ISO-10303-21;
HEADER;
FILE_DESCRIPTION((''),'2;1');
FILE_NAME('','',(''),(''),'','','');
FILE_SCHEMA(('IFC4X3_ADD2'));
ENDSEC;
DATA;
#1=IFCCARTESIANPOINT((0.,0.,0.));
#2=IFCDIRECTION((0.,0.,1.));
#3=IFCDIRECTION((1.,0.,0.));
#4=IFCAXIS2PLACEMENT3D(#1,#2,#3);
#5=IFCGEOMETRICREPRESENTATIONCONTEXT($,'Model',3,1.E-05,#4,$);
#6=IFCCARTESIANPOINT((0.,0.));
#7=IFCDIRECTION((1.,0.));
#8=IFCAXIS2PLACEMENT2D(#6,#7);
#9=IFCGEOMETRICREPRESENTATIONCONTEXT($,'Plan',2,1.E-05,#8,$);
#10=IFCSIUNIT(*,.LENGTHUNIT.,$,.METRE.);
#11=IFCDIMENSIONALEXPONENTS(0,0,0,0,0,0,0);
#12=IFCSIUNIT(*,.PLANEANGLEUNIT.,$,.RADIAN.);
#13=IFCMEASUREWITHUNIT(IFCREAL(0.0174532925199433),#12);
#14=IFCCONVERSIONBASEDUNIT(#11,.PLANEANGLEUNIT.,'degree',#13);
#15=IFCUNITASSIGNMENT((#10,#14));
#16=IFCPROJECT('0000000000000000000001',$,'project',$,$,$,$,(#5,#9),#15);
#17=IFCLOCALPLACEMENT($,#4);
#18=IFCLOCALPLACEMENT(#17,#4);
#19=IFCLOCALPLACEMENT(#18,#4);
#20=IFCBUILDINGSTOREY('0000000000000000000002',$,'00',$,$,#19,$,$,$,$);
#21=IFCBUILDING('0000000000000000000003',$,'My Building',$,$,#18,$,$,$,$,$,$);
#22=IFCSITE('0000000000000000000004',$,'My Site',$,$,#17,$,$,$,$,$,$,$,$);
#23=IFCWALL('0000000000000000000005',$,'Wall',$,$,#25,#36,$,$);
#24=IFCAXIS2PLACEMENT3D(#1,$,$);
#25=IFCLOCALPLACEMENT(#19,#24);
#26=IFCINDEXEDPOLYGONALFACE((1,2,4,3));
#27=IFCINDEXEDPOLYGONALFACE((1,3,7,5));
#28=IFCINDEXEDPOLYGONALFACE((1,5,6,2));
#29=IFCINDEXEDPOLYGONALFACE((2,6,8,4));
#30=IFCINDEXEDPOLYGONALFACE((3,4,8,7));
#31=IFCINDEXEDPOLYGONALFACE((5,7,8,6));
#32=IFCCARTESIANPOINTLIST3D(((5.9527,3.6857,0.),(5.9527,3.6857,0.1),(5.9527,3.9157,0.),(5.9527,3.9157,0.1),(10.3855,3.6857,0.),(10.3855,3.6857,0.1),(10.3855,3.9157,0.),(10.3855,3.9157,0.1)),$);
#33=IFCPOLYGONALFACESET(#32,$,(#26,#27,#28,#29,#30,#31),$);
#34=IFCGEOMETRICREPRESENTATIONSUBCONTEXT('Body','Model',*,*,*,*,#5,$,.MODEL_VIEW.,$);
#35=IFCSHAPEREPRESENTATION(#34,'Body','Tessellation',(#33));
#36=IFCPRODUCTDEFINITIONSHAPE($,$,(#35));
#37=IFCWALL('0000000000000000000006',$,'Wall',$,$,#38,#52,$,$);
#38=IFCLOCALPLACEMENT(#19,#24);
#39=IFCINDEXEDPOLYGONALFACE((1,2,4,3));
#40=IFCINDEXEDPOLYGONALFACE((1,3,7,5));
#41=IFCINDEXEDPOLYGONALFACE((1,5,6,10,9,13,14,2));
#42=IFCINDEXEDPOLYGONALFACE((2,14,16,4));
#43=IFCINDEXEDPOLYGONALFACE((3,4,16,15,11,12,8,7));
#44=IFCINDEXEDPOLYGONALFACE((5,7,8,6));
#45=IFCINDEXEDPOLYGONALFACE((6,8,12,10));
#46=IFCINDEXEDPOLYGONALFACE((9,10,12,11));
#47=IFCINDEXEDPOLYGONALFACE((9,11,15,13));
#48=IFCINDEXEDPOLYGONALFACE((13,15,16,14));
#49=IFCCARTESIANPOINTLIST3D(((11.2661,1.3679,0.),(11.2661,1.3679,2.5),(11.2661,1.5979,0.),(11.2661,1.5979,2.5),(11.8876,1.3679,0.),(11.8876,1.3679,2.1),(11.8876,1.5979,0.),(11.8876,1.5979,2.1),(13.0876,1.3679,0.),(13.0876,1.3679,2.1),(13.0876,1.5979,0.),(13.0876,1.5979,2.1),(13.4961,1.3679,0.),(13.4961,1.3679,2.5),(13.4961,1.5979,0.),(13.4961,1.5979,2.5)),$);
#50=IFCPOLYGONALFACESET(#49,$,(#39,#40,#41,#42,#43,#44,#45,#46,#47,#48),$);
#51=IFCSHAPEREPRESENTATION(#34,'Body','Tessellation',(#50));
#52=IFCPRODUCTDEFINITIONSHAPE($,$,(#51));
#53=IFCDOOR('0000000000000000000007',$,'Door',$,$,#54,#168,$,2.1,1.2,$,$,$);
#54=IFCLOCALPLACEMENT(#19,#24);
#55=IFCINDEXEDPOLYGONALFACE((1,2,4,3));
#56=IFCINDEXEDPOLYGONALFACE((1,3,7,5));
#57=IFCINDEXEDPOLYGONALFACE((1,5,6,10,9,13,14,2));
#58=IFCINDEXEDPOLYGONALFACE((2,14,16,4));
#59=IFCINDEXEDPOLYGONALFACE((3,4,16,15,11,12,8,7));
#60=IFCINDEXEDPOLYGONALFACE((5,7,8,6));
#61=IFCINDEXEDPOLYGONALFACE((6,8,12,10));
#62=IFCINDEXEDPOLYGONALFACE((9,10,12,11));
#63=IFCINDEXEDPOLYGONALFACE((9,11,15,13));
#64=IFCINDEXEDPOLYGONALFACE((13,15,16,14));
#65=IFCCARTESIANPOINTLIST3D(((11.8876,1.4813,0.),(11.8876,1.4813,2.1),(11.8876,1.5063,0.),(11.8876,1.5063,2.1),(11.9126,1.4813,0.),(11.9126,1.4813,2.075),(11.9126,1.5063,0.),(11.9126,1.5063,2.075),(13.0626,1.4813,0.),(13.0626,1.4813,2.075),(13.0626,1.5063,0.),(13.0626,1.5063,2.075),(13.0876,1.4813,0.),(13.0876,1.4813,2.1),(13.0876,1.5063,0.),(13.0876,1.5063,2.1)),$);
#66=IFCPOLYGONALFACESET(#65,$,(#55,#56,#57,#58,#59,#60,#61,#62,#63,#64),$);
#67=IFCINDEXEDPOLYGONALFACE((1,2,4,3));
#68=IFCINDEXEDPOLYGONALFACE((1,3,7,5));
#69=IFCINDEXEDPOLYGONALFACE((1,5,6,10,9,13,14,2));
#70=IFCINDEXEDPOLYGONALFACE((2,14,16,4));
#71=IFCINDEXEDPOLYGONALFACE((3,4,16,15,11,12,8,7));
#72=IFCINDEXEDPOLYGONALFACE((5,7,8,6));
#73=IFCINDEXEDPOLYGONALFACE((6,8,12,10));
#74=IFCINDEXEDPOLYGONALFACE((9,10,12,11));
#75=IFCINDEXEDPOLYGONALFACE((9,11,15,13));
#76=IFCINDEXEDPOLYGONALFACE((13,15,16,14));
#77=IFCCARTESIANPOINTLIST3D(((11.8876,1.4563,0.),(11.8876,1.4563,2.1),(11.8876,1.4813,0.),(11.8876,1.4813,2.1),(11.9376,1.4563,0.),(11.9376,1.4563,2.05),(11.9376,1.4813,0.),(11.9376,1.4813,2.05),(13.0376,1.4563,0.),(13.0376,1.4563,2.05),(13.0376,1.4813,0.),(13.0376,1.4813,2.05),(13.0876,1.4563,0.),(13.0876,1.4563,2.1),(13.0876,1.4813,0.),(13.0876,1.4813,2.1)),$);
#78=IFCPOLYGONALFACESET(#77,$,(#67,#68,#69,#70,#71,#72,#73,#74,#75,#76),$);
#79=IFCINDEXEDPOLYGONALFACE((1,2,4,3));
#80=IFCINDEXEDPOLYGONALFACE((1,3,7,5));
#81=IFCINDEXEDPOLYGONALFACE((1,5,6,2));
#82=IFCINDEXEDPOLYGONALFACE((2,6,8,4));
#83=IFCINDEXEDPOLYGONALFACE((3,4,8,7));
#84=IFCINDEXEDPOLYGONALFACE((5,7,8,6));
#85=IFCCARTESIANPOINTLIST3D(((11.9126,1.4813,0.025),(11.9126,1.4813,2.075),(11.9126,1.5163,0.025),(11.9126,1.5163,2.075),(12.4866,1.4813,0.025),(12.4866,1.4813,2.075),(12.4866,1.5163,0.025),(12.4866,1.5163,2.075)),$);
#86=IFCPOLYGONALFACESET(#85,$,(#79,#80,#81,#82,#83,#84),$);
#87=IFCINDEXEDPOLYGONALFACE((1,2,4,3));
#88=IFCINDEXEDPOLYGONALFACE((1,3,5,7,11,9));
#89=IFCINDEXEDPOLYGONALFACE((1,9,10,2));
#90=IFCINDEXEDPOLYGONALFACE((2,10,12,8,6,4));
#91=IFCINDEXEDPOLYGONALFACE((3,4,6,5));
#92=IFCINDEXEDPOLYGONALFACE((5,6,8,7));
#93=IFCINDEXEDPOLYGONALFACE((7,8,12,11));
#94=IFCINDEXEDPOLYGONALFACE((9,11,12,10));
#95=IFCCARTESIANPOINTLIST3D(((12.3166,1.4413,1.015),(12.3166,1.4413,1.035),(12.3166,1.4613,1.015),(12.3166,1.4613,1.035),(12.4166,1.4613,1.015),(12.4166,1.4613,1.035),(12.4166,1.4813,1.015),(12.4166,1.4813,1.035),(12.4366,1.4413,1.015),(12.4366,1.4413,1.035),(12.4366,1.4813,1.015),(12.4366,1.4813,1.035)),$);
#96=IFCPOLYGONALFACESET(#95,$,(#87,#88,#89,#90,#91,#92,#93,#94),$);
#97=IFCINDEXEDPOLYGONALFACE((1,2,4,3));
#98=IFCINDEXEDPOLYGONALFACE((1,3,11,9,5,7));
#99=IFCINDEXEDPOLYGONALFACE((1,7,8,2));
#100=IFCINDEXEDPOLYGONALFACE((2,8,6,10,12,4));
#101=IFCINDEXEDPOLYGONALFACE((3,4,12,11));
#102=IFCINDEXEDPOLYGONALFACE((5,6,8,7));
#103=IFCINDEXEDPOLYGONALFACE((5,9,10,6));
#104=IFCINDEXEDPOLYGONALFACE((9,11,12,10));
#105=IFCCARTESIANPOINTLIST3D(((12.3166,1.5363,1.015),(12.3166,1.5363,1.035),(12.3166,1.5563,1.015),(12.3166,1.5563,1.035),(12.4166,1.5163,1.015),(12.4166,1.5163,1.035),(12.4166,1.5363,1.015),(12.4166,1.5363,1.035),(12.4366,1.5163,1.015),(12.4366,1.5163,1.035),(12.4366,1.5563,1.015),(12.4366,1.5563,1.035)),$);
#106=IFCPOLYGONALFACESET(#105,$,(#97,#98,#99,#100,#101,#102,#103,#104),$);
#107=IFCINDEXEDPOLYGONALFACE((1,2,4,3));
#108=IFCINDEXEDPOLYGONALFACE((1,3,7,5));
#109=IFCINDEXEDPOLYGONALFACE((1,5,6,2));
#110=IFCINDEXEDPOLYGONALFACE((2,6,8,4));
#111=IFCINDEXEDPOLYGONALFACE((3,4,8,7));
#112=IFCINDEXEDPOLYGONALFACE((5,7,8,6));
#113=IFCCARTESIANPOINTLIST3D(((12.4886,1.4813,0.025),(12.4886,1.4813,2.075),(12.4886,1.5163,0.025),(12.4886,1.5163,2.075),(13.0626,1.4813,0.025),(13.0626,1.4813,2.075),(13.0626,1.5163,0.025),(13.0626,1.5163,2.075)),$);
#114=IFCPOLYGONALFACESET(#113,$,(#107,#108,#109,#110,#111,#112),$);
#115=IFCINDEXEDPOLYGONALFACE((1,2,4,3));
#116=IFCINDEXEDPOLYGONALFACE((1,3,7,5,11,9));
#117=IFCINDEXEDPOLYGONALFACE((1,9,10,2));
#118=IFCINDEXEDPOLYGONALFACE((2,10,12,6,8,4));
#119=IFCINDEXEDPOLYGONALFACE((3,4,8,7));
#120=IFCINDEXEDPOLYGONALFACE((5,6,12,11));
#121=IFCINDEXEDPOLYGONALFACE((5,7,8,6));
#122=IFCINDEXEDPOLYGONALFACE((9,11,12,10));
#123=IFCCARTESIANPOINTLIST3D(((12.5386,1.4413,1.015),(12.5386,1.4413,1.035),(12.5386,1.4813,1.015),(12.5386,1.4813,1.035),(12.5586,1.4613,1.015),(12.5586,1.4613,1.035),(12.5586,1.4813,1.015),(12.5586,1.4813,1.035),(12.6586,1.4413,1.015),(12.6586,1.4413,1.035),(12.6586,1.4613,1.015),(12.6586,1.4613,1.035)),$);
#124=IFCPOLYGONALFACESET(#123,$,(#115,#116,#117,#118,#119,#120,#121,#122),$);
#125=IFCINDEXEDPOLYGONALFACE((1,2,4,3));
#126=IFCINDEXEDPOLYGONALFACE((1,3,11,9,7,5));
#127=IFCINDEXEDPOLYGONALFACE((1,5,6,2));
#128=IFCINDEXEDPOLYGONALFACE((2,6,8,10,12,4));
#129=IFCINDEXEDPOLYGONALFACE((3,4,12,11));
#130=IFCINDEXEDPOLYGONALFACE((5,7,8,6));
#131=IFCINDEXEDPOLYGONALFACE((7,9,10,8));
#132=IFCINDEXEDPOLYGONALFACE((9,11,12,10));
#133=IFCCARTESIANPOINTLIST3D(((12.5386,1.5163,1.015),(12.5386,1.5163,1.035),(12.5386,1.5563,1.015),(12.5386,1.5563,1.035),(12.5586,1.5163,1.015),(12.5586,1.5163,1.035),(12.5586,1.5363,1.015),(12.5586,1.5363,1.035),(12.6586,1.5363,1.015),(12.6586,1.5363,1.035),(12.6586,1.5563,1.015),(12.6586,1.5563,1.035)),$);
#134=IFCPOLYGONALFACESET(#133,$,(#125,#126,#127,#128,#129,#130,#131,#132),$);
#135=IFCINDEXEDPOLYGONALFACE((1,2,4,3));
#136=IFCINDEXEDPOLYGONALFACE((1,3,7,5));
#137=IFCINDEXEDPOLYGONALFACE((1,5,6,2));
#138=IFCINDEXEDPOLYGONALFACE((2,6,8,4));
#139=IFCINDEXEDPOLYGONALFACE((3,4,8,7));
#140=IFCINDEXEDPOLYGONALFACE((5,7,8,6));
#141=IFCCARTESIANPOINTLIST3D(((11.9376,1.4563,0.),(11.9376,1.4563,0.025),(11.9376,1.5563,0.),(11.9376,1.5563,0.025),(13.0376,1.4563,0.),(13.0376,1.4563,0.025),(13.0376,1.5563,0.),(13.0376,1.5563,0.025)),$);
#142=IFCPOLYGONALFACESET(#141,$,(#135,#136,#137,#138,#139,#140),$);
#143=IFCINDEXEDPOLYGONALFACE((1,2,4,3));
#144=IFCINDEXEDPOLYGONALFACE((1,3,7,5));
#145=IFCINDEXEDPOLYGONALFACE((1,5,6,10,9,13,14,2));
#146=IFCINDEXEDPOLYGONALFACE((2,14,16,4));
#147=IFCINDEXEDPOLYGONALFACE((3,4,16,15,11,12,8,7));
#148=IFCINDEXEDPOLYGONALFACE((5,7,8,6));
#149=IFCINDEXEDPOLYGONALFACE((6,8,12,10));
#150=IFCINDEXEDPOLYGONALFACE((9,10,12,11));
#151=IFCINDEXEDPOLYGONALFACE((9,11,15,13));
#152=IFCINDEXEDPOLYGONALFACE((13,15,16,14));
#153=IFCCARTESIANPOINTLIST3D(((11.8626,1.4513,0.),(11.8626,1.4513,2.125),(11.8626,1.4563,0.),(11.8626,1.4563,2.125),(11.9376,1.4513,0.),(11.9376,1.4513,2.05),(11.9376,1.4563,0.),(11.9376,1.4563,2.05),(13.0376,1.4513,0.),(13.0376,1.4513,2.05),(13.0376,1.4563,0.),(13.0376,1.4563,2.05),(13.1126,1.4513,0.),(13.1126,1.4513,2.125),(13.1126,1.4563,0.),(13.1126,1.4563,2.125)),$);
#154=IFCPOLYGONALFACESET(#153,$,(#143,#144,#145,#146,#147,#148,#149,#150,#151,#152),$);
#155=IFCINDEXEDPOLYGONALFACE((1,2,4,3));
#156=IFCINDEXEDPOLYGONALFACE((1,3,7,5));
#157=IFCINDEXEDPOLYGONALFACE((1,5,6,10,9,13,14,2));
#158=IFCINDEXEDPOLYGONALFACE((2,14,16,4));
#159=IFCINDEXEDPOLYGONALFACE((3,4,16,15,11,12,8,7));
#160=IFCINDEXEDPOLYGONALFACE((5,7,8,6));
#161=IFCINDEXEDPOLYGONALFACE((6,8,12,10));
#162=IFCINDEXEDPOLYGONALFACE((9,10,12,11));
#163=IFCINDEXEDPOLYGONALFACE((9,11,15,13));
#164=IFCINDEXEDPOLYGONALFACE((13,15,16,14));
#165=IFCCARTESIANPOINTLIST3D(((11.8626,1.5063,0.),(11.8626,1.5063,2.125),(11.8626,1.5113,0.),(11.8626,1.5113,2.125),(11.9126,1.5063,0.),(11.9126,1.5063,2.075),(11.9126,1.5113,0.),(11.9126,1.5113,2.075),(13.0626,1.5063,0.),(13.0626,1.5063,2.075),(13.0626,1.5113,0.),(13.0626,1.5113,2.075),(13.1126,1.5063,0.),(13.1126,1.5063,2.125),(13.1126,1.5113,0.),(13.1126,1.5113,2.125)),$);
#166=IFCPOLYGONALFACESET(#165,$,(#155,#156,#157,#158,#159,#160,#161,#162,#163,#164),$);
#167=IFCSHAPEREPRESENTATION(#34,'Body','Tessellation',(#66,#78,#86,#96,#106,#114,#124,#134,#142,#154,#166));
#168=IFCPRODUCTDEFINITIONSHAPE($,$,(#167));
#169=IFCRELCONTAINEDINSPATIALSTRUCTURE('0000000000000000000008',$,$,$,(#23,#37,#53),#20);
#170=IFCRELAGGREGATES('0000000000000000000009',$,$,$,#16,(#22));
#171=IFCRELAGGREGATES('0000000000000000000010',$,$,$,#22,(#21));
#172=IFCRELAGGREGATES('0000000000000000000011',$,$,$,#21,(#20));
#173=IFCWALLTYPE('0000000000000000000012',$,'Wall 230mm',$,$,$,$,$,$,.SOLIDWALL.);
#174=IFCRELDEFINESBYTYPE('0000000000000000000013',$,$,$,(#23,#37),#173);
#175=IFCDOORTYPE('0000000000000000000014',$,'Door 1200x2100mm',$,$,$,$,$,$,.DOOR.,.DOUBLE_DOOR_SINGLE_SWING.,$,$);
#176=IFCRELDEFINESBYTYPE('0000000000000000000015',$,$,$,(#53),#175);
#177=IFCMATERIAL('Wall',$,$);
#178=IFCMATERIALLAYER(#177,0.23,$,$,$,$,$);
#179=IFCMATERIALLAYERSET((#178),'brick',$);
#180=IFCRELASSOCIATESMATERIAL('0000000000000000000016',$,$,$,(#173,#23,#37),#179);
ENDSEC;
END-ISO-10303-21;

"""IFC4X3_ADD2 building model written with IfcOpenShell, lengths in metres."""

from ifc_helpers import new_model, entity, si_unit, converted_unit, frame, origin_with_axes, origin_2d_with_axis, place, context, subcontext, project, spatial, line, indexed_curve, outline, extrude, shape, source, transform, mapped, material, layer, layer_set, layer_usage, type_object, type_shapes, element, fill, save


model = new_model("IFC4X3_ADD2")

# Units and contexts
model_context = context("Model", 3, precision=1e-05, world=origin_with_axes())
plan_context = context("Plan", 2, precision=1e-05, world=origin_2d_with_axis())
body_context_1 = subcontext(model_context, "Body", "Model", "MODEL_VIEW")
body_context_2 = subcontext(plan_context, "Body", "Plan", "PLAN_VIEW")
ifc_project = project(units=[si_unit("LENGTHUNIT", "METRE"), converted_unit("PLANEANGLEUNIT", "degree", entity("IfcReal", 0.0174532925199433), si_unit("PLANEANGLEUNIT", "RADIAN"), dimensions=[0, 0, 0, 0, 0, 0, 0])], contexts=[model_context, plan_context])

# Site, building, storey
site_placement = place(None, origin_with_axes())
site = spatial("IfcSite", under=ifc_project, at=site_placement, Name="My Site")
building_placement = place(site_placement, origin_with_axes())
building = spatial("IfcBuilding", under=site, at=building_placement, Name="My Building")
storey_placement = place(building_placement, origin_with_axes())
storey = spatial("IfcBuildingStorey", under=building, at=storey_placement, Name="00")

# Wall
ifc_material_1 = material(Name="Wall")
ifc_layer_1 = layer(ifc_material_1, 0.23)
ifc_layer_set_1 = layer_set([ifc_layer_1], Name="brick")
ifc_layer_usage_1 = layer_usage(ifc_layer_set_1, "AXIS2", "POSITIVE", 0.0)
wall_type_1 = type_object("IfcWallType", Name="Wall 230mm", PredefinedType="SOLIDWALL", material=ifc_layer_set_1)
wall_1_placement = place(storey_placement, frame((5.9527, 3.6857, 0.0), z_axis=(0.0, 0.0, 1.0), x_axis=(1.0, 0.0, 0.0)))
element("IfcWall", 1, at=wall_1_placement, inside=storey, type_object=wall_type_1, material=ifc_layer_usage_1, Name="Wall", context=body_context_1, shape_type="SweptSolid", body=[
    extrude(outline(indexed_curve([(0.0, 0.0), (0.0, 0.23), (4.4327, 0.23), (4.4327, 0.0), (0.0, 0.0)], self_intersect=False)), origin_with_axes(), (0.0, 0.0, 1.0), 0.1),
])

# Wall, opening, door
ifc_layer_usage_2 = layer_usage(ifc_layer_set_1, "AXIS2", "POSITIVE", 0.0)
wall_2_placement = place(storey_placement, frame((11.2661, 1.3679, 0.0), z_axis=(0.0, 0.0, 1.0), x_axis=(1.0, 0.0, 0.0)))
wall_2 = element("IfcWall", 2, at=wall_2_placement, inside=storey, type_object=wall_type_1, material=ifc_layer_usage_2, Name="Wall", context=body_context_1, shape_type="SweptSolid", body=[
    extrude(outline(indexed_curve([(0.0, 0.0), (0.0, 0.23), (2.23, 0.23), (2.23, 0.0), (0.0, 0.0)], self_intersect=False)), origin_with_axes(), (0.0, 0.0, 1.0), 2.5),
])
shared_shape_1 = source(origin_with_axes(), body_context_1, "Body", "SweptSolid", [
    extrude(outline(indexed_curve([(0.0, 0.0), (1.2, 0.0), (1.2, 2.1), (0.0, 2.1)], segments=[line(1, 2, 3, 4, 1)])), frame((0.0, -0.6, 0.0), z_axis=(0.0, -1.0, 0.0), x_axis=(1.0, 0.0, 0.0)), (0.0, 0.0, -1.0), 1.2),
])
opening_1_placement = place(wall_2_placement, frame((0.6215, 0.0885, 0.0), z_axis=(0.0, 0.0, 1.0), x_axis=(1.0, 0.0, 0.0)))
opening_1 = element("IfcOpeningElement", 3, at=opening_1_placement, cuts=wall_2, PredefinedType="OPENING", context=body_context_1, shape_type="MappedRepresentation", body=[
    mapped(shared_shape_1, transform((0.0, 0.0, 0.0), x_axis=(1.0, 0.0, 0.0), y_axis=(0.0, 1.0, 0.0), z_axis=(0.0, 0.0, 1.0), scale=1.0)),
])
door_type_1 = type_object("IfcDoorType", Name="Door 1200x2100mm", OperationType="DOUBLE_DOOR_SINGLE_SWING", PredefinedType="DOOR")
shared_shape_2 = source(origin_with_axes(), body_context_1, "Body", "SweptSolid", [
    extrude(outline(indexed_curve([(0.0, 0.0), (0.0, 2.1), (1.2, 2.1), (1.2, 0.0), (1.175, 0.0), (1.175, 2.075), (0.025, 2.075), (0.025, 0.0)], segments=[line(1, 2, 3, 4, 5, 6, 7, 8, 1)])), frame((0.0, 0.025, 0.0), z_axis=(0.0, -1.0, 0.0), x_axis=(1.0, 0.0, 0.0)), (0.0, 0.0, -1.0), 0.025),
    extrude(outline(indexed_curve([(0.0, 0.0), (0.0, 2.1), (1.2, 2.1), (1.2, 0.0), (1.15, 0.0), (1.15, 2.05), (0.05, 2.05), (0.05, 0.0)], segments=[line(1, 2, 3, 4, 5, 6, 7, 8, 1)])), frame((0.0, 0.0, 0.0), z_axis=(0.0, -1.0, 0.0), x_axis=(1.0, 0.0, 0.0)), (0.0, 0.0, -1.0), 0.025),
    extrude(outline(indexed_curve([(0.0, 0.0), (0.574, 0.0), (0.574, 0.035), (0.0, 0.035)], segments=[line(1, 2, 3, 4, 1)])), frame((0.025, 0.025, 0.025), z_axis=(0.0, 0.0, 1.0), x_axis=(1.0, 0.0, 0.0)), (0.0, 0.0, 1.0), 2.05),
    extrude(outline(indexed_curve([(0.0, 0.0), (0.0, -0.04), (-0.12, -0.04), (-0.12, -0.02), (-0.02, -0.02), (-0.02, 0.0)], segments=[line(1, 2, 3, 4, 5, 6, 1)])), frame((0.549, 0.025, 1.015), z_axis=(0.0, 0.0, 1.0), x_axis=(1.0, 0.0, 0.0)), (0.0, 0.0, 1.0), 0.02),
    extrude(outline(indexed_curve([(0.0, 0.0), (0.0, 0.04), (-0.12, 0.04), (-0.12, 0.02), (-0.02, 0.02), (-0.02, 0.0)], segments=[line(1, 2, 3, 4, 5, 6, 1)])), frame((0.549, 0.06, 1.015), z_axis=(0.0, 0.0, 1.0), x_axis=(1.0, 0.0, 0.0)), (0.0, 0.0, 1.0), 0.02),
    extrude(outline(indexed_curve([(0.0, 0.0), (-0.574, 0.0), (-0.574, 0.035), (0.0, 0.035)], segments=[line(1, 2, 3, 4, 1)])), frame((1.175, 0.025, 0.025), z_axis=(0.0, 0.0, 1.0), x_axis=(1.0, 0.0, 0.0)), (0.0, 0.0, 1.0), 2.05),
    extrude(outline(indexed_curve([(0.0, 0.0), (0.0, -0.04), (0.12, -0.04), (0.12, -0.02), (0.02, -0.02), (0.02, 0.0)], segments=[line(1, 2, 3, 4, 5, 6, 1)])), frame((0.651, 0.025, 1.015), z_axis=(0.0, 0.0, 1.0), x_axis=(1.0, 0.0, 0.0)), (0.0, 0.0, 1.0), 0.02),
    extrude(outline(indexed_curve([(0.0, 0.0), (0.0, 0.04), (0.12, 0.04), (0.12, 0.02), (0.02, 0.02), (0.02, 0.0)], segments=[line(1, 2, 3, 4, 5, 6, 1)])), frame((0.651, 0.06, 1.015), z_axis=(0.0, 0.0, 1.0), x_axis=(1.0, 0.0, 0.0)), (0.0, 0.0, 1.0), 0.02),
    extrude(outline(indexed_curve([(0.0, 0.0), (1.1, 0.0), (1.1, 0.1), (0.0, 0.1)], segments=[line(1, 2, 3, 4, 1)])), frame((0.05, 0.0, 0.0), z_axis=(0.0, 0.0, 1.0), x_axis=(1.0, 0.0, 0.0)), (0.0, 0.0, 1.0), 0.025),
    extrude(outline(indexed_curve([(0.0, 0.0), (0.0, 2.125), (1.25, 2.125), (1.25, 0.0), (1.175, 0.0), (1.175, 2.05), (0.075, 2.05), (0.075, 0.0)], segments=[line(1, 2, 3, 4, 5, 6, 7, 8, 1)])), frame((-0.025, -0.005, 0.0), z_axis=(0.0, -1.0, 0.0), x_axis=(1.0, 0.0, 0.0)), (0.0, 0.0, -1.0), 0.005),
    extrude(outline(indexed_curve([(0.0, 0.0), (0.0, 2.125), (1.25, 2.125), (1.25, 0.0), (1.2, 0.0), (1.2, 2.075), (0.05, 2.075), (0.05, 0.0)], segments=[line(1, 2, 3, 4, 5, 6, 7, 8, 1)])), frame((-0.025, 0.05, 0.0), z_axis=(0.0, -1.0, 0.0), x_axis=(1.0, 0.0, 0.0)), (0.0, 0.0, -1.0), 0.005),
])
shared_shape_3 = source(origin_with_axes(), body_context_2, "Body", "Curve2D", [
    entity("IfcIndexedPolyCurve", entity("IfcCartesianPointList2D", [[0.0, 0.0], [0.0, 0.05], [0.025, 0.05], [0.025, 0.025], [0.05, 0.025], [0.05, 0.0]]), [entity("IfcLineIndex", [1, 2, 3, 4, 5, 6, 1])]),
    entity("IfcIndexedPolyCurve", entity("IfcCartesianPointList2D", [[1.2, 0.0], [1.2, 0.05], [1.175, 0.05], [1.175, 0.025], [1.15, 0.025], [1.15, 0.0]]), [entity("IfcLineIndex", [1, 2, 3, 4, 5, 6, 1])]),
    entity("IfcTrimmedCurve", entity("IfcEllipse", entity("IfcAxis2Placement2D", entity("IfcCartesianPoint", [0.06, 0.05]), entity("IfcDirection", [1.0, 0.0])), 0.54, 0.575), [entity("IfcCartesianPoint", [0.6, 0.05])], [entity("IfcCartesianPoint", [0.06, 0.625])], True, "CARTESIAN"),
    entity("IfcIndexedPolyCurve", entity("IfcCartesianPointList2D", [[0.025, 0.05], [0.06, 0.05], [0.06, 0.625], [0.025, 0.625]]), [entity("IfcLineIndex", [1, 2, 3, 4, 1])]),
    entity("IfcTrimmedCurve", entity("IfcEllipse", entity("IfcAxis2Placement2D", entity("IfcCartesianPoint", [1.14, 0.05]), entity("IfcDirection", [1.0, 0.0])), 0.54, 0.575), [entity("IfcCartesianPoint", [1.14, 0.625])], [entity("IfcCartesianPoint", [0.6, 0.05])], True, "CARTESIAN"),
    entity("IfcIndexedPolyCurve", entity("IfcCartesianPointList2D", [[1.175, 0.05], [1.14, 0.05], [1.14, 0.625], [1.175, 0.625]]), [entity("IfcLineIndex", [1, 2, 3, 4, 1])]),
])
type_shapes(door_type_1, [shared_shape_2, shared_shape_3])
door_1_placement = place(opening_1_placement, origin_with_axes())
door_1 = element("IfcDoor", 4, at=door_1_placement, inside=storey, type_object=door_type_1, Name="Door", OverallHeight=2.1, OverallWidth=1.2, shapes=[
    shape(body_context_1, "Body", "MappedRepresentation", [mapped(shared_shape_2, transform((0.0, 0.0, 0.0), x_axis=(1.0, 0.0, 0.0), y_axis=(0.0, 1.0, 0.0), z_axis=(0.0, 0.0, 1.0), scale=1.0))]),
    shape(body_context_2, "Body", "MappedRepresentation", [mapped(shared_shape_3, transform((0.0, 0.0, 0.0), x_axis=(1.0, 0.0, 0.0), y_axis=(0.0, 1.0, 0.0), z_axis=(0.0, 0.0, 1.0), scale=1.0))]),
])
fill(opening_1, door_1)

save(model, "model.ifc")
